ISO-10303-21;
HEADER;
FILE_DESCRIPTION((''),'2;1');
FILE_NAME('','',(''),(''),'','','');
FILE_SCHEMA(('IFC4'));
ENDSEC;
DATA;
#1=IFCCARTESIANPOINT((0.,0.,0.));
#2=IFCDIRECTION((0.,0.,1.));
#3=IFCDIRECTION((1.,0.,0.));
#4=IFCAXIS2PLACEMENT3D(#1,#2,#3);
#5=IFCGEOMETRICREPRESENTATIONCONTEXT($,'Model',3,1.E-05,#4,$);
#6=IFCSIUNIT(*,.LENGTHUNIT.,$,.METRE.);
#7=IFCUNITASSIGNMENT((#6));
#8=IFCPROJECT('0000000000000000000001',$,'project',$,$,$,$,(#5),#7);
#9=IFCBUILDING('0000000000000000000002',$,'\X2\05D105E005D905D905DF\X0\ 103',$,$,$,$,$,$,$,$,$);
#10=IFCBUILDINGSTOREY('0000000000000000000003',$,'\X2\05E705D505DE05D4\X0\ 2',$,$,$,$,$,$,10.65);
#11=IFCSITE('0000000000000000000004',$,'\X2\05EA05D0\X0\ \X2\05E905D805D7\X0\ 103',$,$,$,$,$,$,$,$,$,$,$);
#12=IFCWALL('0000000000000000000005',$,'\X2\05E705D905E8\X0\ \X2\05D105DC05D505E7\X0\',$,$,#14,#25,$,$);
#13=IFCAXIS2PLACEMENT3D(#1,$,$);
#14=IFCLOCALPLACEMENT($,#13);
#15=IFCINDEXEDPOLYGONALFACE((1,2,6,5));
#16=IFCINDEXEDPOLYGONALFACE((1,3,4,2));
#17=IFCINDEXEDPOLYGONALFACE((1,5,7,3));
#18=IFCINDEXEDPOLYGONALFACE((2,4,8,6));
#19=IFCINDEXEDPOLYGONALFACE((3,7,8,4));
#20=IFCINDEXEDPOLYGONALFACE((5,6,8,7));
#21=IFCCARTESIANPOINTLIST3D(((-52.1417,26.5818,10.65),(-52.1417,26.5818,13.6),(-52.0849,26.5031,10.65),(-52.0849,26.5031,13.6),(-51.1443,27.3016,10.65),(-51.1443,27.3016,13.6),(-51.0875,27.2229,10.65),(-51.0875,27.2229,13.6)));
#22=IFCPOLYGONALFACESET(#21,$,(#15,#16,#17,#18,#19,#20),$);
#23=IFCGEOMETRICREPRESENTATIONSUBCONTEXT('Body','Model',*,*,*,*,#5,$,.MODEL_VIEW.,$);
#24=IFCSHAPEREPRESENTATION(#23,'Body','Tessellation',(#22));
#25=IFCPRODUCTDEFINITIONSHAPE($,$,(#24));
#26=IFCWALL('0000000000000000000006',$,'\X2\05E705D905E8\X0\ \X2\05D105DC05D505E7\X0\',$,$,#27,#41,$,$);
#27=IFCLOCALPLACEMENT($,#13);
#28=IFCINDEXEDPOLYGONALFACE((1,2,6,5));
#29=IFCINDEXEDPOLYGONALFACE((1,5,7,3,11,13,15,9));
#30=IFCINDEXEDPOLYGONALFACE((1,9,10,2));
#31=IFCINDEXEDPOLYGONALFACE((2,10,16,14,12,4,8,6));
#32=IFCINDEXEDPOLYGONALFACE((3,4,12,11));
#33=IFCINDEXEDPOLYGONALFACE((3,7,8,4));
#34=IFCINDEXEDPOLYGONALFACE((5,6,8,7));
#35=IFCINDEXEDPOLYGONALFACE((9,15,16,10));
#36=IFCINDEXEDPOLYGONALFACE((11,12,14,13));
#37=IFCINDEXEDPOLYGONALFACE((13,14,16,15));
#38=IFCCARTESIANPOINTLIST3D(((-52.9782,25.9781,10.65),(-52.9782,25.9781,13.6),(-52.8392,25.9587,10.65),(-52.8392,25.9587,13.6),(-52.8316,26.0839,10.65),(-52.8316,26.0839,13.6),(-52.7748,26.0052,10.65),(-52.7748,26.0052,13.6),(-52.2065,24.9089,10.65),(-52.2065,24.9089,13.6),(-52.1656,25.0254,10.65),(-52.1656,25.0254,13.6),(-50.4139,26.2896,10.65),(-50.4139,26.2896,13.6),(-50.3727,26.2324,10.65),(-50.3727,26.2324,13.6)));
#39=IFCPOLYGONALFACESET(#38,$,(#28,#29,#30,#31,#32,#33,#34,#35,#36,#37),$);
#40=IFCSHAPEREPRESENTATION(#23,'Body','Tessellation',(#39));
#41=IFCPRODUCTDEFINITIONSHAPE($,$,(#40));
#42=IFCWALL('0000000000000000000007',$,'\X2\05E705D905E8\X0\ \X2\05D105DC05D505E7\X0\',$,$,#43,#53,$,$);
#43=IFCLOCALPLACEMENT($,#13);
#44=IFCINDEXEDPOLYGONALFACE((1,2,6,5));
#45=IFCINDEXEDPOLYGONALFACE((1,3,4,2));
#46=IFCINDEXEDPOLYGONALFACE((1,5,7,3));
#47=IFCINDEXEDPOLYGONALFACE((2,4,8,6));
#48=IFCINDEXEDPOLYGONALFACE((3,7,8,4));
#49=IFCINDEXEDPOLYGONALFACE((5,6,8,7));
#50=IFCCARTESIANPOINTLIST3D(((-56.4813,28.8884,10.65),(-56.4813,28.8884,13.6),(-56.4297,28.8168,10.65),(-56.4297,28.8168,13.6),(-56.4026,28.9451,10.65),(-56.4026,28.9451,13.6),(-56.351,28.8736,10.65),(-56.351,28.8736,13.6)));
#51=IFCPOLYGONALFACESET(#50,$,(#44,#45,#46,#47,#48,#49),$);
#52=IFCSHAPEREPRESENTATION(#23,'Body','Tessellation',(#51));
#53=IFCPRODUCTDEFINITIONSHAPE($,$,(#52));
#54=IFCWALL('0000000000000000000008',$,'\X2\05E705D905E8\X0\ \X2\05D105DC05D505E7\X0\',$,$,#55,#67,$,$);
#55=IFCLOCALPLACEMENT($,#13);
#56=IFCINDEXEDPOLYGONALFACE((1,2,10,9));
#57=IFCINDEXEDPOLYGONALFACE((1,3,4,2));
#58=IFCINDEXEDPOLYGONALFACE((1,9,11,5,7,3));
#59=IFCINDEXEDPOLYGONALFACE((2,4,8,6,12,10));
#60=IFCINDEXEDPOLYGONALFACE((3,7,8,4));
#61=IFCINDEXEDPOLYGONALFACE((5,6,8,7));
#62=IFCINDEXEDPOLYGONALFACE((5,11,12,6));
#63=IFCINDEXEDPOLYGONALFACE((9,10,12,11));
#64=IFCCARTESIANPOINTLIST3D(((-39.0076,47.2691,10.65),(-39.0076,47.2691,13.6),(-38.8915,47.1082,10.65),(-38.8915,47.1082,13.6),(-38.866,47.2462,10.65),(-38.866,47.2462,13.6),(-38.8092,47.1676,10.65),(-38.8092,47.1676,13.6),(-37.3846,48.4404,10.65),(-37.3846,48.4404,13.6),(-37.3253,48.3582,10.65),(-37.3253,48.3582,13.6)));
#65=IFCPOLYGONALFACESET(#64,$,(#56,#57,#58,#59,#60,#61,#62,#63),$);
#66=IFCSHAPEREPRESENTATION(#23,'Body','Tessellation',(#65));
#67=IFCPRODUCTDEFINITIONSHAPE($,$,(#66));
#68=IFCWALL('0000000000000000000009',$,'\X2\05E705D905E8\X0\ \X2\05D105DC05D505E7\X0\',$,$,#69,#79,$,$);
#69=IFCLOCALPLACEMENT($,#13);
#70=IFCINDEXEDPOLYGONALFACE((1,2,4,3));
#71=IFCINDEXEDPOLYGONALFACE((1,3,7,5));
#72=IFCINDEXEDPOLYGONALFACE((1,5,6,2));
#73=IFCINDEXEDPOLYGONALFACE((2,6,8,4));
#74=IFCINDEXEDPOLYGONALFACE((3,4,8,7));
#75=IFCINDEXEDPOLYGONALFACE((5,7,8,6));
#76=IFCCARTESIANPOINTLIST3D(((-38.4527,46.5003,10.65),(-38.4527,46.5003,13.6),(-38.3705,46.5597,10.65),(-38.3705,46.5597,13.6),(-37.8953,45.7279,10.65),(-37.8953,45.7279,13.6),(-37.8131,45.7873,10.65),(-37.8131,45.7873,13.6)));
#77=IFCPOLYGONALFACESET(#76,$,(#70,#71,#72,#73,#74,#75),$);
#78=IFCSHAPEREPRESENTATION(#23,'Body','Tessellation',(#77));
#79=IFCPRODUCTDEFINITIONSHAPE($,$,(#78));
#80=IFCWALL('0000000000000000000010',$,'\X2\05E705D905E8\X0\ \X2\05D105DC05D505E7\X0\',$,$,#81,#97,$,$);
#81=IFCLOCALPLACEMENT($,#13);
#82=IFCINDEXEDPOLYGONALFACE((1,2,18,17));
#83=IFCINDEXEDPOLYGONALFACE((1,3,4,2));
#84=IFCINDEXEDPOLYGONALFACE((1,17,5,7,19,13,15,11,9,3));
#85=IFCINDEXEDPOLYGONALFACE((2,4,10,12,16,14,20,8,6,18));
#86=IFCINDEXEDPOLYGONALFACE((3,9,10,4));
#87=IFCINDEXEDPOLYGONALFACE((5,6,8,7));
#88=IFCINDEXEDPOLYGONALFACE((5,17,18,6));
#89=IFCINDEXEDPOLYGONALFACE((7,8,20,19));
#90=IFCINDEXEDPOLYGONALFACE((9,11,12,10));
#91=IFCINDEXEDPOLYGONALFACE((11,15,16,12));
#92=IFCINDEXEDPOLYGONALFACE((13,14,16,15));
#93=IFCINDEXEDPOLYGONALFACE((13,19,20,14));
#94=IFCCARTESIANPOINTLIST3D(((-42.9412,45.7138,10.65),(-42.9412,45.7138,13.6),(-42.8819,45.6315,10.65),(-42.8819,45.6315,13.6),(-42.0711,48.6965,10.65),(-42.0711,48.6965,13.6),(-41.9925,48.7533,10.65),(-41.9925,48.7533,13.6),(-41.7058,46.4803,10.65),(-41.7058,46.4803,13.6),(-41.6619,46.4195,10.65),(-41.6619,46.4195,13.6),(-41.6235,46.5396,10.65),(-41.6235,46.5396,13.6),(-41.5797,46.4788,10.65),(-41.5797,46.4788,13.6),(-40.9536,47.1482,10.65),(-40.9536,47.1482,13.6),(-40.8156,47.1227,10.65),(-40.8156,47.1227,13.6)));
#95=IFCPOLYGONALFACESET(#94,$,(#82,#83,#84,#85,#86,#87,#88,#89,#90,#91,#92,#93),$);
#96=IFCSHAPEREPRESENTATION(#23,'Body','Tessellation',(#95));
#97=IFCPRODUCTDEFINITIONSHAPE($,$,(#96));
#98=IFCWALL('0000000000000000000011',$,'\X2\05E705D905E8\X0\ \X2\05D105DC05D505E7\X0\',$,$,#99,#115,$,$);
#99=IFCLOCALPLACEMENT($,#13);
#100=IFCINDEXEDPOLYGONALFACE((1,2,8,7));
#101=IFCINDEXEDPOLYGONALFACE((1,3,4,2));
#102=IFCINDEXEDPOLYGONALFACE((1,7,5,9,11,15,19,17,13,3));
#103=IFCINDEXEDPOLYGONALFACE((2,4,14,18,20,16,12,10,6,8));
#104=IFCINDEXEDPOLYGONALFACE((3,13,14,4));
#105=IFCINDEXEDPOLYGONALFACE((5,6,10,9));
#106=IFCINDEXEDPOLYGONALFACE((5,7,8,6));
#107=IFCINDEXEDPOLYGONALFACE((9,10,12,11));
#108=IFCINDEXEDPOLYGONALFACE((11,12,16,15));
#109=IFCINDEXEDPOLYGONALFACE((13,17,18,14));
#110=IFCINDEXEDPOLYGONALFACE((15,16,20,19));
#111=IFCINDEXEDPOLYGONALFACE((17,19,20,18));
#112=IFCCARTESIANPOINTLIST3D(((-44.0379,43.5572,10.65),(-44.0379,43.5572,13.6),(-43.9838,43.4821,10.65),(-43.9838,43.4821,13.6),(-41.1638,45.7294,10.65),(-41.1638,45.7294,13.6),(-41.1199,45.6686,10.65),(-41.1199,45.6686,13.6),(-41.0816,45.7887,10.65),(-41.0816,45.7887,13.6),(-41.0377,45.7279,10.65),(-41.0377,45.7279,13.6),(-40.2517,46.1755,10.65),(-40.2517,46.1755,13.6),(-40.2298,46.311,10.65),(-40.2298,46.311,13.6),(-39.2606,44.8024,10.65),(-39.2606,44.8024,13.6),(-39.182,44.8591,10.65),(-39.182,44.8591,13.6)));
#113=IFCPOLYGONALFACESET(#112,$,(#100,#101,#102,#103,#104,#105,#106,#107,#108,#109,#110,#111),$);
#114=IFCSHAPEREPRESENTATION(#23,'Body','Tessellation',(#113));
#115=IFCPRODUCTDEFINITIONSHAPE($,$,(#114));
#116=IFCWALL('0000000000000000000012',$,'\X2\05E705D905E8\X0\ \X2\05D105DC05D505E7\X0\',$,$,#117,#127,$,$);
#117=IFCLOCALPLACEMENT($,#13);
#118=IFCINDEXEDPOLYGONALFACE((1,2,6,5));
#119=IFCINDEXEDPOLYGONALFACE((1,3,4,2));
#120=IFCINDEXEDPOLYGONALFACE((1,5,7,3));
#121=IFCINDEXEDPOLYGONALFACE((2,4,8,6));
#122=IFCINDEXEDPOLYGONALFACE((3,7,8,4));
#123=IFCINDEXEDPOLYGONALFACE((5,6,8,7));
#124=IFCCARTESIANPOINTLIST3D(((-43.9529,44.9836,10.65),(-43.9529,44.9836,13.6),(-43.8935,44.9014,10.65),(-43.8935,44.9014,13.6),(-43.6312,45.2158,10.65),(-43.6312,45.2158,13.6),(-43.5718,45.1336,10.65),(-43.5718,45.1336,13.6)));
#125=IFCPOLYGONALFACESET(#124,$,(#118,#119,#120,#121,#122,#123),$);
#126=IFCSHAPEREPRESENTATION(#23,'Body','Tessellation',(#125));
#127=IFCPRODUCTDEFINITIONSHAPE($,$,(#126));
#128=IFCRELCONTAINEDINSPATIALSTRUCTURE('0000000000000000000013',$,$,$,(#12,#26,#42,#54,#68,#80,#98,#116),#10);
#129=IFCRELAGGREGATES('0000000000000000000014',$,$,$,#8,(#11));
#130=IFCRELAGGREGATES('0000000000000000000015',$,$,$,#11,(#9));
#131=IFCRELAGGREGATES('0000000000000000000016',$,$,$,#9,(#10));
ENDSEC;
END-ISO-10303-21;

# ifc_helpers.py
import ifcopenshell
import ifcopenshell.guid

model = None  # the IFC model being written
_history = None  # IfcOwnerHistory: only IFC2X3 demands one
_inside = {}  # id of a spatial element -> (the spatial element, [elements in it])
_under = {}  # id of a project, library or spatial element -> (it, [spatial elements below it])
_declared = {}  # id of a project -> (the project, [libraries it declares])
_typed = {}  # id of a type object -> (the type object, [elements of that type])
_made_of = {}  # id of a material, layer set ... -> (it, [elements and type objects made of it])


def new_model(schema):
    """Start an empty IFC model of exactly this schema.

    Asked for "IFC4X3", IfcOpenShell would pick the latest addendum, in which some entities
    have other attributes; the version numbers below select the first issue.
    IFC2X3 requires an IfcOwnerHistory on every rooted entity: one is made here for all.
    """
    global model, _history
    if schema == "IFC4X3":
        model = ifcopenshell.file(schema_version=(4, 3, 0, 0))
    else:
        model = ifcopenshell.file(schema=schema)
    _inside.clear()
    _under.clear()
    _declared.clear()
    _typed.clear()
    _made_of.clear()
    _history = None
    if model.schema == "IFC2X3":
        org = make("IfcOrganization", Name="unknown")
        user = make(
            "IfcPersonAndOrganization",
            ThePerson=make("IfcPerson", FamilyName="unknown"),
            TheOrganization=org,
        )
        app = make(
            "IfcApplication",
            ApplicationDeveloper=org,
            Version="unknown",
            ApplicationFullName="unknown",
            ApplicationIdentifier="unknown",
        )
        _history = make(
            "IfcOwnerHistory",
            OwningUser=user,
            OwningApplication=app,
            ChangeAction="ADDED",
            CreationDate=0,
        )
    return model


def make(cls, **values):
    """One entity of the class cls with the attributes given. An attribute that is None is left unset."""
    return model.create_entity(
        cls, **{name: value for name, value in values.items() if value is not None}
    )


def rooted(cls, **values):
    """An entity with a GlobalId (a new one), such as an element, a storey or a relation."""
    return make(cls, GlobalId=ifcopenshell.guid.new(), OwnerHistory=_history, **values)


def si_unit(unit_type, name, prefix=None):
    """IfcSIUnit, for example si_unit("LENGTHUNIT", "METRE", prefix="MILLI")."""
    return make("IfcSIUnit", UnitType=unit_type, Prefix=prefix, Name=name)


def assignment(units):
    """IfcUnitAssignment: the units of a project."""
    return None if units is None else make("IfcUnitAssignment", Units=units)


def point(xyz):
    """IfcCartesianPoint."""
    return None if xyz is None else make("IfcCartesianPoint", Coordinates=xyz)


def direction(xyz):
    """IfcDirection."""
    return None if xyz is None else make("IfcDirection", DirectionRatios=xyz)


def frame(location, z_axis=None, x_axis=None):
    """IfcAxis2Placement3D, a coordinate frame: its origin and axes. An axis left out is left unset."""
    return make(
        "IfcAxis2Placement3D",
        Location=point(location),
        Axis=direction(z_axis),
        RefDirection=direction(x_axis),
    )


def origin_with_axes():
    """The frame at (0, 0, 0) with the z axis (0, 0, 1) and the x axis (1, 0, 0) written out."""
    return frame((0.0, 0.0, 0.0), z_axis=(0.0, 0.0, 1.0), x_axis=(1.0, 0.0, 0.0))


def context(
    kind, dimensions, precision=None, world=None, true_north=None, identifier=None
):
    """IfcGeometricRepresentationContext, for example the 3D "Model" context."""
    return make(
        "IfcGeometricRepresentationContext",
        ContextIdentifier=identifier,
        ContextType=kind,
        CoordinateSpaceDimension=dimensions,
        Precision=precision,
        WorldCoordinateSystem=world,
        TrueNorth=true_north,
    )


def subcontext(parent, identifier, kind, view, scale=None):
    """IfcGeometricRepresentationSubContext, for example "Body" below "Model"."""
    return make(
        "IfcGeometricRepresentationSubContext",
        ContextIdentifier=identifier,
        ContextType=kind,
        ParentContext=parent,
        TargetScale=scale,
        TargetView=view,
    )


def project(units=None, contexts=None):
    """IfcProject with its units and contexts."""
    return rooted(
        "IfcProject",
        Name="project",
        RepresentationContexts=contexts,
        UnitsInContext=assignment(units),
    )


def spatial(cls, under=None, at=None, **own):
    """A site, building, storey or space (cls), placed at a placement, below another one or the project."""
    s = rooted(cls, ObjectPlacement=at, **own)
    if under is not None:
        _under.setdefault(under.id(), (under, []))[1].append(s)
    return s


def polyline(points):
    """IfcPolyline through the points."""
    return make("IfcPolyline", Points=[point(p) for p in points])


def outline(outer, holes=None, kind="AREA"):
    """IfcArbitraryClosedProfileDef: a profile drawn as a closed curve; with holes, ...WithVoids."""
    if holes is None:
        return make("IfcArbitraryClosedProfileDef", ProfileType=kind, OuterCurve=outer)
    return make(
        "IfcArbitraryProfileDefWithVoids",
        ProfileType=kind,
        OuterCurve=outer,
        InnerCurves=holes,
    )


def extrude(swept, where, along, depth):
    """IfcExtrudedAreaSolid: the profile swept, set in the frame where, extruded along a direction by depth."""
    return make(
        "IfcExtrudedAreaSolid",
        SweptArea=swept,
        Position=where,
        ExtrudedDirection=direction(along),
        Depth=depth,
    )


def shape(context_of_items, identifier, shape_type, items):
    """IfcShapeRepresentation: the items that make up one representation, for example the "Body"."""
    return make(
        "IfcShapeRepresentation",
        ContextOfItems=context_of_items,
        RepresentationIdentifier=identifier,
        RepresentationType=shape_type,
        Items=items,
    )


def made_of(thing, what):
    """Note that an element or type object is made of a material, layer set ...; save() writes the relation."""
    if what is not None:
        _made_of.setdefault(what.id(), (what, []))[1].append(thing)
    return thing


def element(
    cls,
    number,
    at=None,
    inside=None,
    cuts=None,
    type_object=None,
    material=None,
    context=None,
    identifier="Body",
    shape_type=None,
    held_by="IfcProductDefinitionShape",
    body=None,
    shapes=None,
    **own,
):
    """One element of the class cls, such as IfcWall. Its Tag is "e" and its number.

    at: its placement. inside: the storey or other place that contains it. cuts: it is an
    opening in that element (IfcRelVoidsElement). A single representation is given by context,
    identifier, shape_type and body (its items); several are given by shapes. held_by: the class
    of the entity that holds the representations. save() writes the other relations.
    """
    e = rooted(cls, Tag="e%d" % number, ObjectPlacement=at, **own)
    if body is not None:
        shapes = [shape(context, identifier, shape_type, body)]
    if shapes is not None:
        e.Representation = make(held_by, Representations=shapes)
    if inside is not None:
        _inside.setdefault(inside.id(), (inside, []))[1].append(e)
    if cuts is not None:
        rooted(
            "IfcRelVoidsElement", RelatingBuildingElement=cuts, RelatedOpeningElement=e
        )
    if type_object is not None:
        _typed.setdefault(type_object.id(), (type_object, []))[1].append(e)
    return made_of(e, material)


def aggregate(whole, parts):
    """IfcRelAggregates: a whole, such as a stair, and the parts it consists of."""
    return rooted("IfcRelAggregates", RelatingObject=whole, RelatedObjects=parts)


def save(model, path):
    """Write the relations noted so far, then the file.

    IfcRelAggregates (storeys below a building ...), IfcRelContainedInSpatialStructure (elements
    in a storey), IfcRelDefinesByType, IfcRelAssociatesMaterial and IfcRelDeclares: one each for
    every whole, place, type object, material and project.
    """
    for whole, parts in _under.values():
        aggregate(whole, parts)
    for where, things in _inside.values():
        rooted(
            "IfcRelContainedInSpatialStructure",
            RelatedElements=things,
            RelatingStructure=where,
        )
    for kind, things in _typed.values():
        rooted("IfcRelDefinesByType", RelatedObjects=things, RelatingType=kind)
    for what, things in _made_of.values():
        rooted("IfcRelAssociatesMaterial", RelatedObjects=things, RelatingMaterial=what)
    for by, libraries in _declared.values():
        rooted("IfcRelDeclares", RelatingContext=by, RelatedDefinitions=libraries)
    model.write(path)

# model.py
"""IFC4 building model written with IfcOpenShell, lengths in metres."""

from ifc_helpers import new_model, si_unit, frame, origin_with_axes, context, subcontext, project, spatial, polyline, outline, extrude, element, save


model = new_model("IFC4")

# Units and contexts
model_context = context("Model", 3, precision=1e-05, world=origin_with_axes())
body_context = subcontext(model_context, "Body", "Model", "MODEL_VIEW")
ifc_project = project(units=[si_unit("LENGTHUNIT", "METRE")], contexts=[model_context])

# Site, building, storey
site = spatial("IfcSite", under=ifc_project, Name="תא שטח 103")
building = spatial("IfcBuilding", under=site, Name="בניין 103")
storey = spatial("IfcBuildingStorey", under=building, Name="קומה 2", Elevation=10.65)

# Walls
element("IfcWall", 1, inside=storey, Name="קיר בלוק", context=body_context, shape_type="SweptSolid", body=[
    extrude(outline(polyline([(-52.0849, 26.5031), (-52.1417, 26.5818), (-51.1443, 27.3016), (-51.0875, 27.2229), (-52.0849, 26.5031)])), frame((0.0, 0.0, 10.65)), (0.0, 0.0, 1.0), 2.95),
])
element("IfcWall", 2, inside=storey, Name="קיר בלוק", context=body_context, shape_type="SweptSolid", body=[
    extrude(outline(polyline([(-52.2065, 24.9089), (-52.9782, 25.9781), (-52.8316, 26.0839), (-52.7748, 26.0052), (-52.8392, 25.9587), (-52.1656, 25.0254), (-50.4139, 26.2896), (-50.3727, 26.2324), (-52.2065, 24.9089)])), frame((0.0, 0.0, 10.65)), (0.0, 0.0, 1.0), 2.95),
])
element("IfcWall", 3, inside=storey, Name="קיר בלוק", context=body_context, shape_type="SweptSolid", body=[
    extrude(outline(polyline([(-56.4026, 28.9451), (-56.351, 28.8736), (-56.4297, 28.8168), (-56.4813, 28.8884), (-56.4026, 28.9451)])), frame((0.0, 0.0, 10.65)), (0.0, 0.0, 1.0), 2.95),
])
element("IfcWall", 4, inside=storey, Name="קיר בלוק", context=body_context, shape_type="SweptSolid", body=[
    extrude(outline(polyline([(-38.8915, 47.1082), (-39.0076, 47.2691), (-37.3846, 48.4404), (-37.3253, 48.3582), (-38.866, 47.2462), (-38.8092, 47.1676), (-38.8915, 47.1082)])), frame((0.0, 0.0, 10.65)), (0.0, 0.0, 1.0), 2.95),
])
element("IfcWall", 5, inside=storey, Name="קיר בלוק", context=body_context, shape_type="SweptSolid", body=[
    extrude(outline(polyline([(-38.3705, 46.5597), (-37.8131, 45.7873), (-37.8953, 45.7279), (-38.4527, 46.5003), (-38.3705, 46.5597)])), frame((0.0, 0.0, 10.65)), (0.0, 0.0, 1.0), 2.95),
])
element("IfcWall", 6, inside=storey, Name="קיר בלוק", context=body_context, shape_type="SweptSolid", body=[
    extrude(outline(polyline([(-41.6619, 46.4195), (-41.7058, 46.4803), (-42.8819, 45.6315), (-42.9412, 45.7138), (-40.9536, 47.1482), (-42.0711, 48.6965), (-41.9925, 48.7533), (-40.8156, 47.1227), (-41.6235, 46.5396), (-41.5797, 46.4788), (-41.6619, 46.4195)])), frame((0.0, 0.0, 10.65)), (0.0, 0.0, 1.0), 2.95),
])
element("IfcWall", 7, inside=storey, Name="קיר בלוק", context=body_context, shape_type="SweptSolid", body=[
    extrude(outline(polyline([(-44.0379, 43.5572), (-41.1199, 45.6686), (-41.1638, 45.7294), (-41.0816, 45.7887), (-41.0377, 45.7279), (-40.2298, 46.311), (-39.182, 44.8591), (-39.2606, 44.8024), (-40.2517, 46.1755), (-43.9838, 43.4821), (-44.0379, 43.5572)])), frame((0.0, 0.0, 10.65)), (0.0, 0.0, 1.0), 2.95),
])
element("IfcWall", 8, inside=storey, Name="קיר בלוק", context=body_context, shape_type="SweptSolid", body=[
    extrude(outline(polyline([(-43.6312, 45.2158), (-43.5718, 45.1336), (-43.8935, 44.9014), (-43.9529, 44.9836), (-43.6312, 45.2158)])), frame((0.0, 0.0, 10.65)), (0.0, 0.0, 1.0), 2.95),
])

save(model, "model.ifc")
